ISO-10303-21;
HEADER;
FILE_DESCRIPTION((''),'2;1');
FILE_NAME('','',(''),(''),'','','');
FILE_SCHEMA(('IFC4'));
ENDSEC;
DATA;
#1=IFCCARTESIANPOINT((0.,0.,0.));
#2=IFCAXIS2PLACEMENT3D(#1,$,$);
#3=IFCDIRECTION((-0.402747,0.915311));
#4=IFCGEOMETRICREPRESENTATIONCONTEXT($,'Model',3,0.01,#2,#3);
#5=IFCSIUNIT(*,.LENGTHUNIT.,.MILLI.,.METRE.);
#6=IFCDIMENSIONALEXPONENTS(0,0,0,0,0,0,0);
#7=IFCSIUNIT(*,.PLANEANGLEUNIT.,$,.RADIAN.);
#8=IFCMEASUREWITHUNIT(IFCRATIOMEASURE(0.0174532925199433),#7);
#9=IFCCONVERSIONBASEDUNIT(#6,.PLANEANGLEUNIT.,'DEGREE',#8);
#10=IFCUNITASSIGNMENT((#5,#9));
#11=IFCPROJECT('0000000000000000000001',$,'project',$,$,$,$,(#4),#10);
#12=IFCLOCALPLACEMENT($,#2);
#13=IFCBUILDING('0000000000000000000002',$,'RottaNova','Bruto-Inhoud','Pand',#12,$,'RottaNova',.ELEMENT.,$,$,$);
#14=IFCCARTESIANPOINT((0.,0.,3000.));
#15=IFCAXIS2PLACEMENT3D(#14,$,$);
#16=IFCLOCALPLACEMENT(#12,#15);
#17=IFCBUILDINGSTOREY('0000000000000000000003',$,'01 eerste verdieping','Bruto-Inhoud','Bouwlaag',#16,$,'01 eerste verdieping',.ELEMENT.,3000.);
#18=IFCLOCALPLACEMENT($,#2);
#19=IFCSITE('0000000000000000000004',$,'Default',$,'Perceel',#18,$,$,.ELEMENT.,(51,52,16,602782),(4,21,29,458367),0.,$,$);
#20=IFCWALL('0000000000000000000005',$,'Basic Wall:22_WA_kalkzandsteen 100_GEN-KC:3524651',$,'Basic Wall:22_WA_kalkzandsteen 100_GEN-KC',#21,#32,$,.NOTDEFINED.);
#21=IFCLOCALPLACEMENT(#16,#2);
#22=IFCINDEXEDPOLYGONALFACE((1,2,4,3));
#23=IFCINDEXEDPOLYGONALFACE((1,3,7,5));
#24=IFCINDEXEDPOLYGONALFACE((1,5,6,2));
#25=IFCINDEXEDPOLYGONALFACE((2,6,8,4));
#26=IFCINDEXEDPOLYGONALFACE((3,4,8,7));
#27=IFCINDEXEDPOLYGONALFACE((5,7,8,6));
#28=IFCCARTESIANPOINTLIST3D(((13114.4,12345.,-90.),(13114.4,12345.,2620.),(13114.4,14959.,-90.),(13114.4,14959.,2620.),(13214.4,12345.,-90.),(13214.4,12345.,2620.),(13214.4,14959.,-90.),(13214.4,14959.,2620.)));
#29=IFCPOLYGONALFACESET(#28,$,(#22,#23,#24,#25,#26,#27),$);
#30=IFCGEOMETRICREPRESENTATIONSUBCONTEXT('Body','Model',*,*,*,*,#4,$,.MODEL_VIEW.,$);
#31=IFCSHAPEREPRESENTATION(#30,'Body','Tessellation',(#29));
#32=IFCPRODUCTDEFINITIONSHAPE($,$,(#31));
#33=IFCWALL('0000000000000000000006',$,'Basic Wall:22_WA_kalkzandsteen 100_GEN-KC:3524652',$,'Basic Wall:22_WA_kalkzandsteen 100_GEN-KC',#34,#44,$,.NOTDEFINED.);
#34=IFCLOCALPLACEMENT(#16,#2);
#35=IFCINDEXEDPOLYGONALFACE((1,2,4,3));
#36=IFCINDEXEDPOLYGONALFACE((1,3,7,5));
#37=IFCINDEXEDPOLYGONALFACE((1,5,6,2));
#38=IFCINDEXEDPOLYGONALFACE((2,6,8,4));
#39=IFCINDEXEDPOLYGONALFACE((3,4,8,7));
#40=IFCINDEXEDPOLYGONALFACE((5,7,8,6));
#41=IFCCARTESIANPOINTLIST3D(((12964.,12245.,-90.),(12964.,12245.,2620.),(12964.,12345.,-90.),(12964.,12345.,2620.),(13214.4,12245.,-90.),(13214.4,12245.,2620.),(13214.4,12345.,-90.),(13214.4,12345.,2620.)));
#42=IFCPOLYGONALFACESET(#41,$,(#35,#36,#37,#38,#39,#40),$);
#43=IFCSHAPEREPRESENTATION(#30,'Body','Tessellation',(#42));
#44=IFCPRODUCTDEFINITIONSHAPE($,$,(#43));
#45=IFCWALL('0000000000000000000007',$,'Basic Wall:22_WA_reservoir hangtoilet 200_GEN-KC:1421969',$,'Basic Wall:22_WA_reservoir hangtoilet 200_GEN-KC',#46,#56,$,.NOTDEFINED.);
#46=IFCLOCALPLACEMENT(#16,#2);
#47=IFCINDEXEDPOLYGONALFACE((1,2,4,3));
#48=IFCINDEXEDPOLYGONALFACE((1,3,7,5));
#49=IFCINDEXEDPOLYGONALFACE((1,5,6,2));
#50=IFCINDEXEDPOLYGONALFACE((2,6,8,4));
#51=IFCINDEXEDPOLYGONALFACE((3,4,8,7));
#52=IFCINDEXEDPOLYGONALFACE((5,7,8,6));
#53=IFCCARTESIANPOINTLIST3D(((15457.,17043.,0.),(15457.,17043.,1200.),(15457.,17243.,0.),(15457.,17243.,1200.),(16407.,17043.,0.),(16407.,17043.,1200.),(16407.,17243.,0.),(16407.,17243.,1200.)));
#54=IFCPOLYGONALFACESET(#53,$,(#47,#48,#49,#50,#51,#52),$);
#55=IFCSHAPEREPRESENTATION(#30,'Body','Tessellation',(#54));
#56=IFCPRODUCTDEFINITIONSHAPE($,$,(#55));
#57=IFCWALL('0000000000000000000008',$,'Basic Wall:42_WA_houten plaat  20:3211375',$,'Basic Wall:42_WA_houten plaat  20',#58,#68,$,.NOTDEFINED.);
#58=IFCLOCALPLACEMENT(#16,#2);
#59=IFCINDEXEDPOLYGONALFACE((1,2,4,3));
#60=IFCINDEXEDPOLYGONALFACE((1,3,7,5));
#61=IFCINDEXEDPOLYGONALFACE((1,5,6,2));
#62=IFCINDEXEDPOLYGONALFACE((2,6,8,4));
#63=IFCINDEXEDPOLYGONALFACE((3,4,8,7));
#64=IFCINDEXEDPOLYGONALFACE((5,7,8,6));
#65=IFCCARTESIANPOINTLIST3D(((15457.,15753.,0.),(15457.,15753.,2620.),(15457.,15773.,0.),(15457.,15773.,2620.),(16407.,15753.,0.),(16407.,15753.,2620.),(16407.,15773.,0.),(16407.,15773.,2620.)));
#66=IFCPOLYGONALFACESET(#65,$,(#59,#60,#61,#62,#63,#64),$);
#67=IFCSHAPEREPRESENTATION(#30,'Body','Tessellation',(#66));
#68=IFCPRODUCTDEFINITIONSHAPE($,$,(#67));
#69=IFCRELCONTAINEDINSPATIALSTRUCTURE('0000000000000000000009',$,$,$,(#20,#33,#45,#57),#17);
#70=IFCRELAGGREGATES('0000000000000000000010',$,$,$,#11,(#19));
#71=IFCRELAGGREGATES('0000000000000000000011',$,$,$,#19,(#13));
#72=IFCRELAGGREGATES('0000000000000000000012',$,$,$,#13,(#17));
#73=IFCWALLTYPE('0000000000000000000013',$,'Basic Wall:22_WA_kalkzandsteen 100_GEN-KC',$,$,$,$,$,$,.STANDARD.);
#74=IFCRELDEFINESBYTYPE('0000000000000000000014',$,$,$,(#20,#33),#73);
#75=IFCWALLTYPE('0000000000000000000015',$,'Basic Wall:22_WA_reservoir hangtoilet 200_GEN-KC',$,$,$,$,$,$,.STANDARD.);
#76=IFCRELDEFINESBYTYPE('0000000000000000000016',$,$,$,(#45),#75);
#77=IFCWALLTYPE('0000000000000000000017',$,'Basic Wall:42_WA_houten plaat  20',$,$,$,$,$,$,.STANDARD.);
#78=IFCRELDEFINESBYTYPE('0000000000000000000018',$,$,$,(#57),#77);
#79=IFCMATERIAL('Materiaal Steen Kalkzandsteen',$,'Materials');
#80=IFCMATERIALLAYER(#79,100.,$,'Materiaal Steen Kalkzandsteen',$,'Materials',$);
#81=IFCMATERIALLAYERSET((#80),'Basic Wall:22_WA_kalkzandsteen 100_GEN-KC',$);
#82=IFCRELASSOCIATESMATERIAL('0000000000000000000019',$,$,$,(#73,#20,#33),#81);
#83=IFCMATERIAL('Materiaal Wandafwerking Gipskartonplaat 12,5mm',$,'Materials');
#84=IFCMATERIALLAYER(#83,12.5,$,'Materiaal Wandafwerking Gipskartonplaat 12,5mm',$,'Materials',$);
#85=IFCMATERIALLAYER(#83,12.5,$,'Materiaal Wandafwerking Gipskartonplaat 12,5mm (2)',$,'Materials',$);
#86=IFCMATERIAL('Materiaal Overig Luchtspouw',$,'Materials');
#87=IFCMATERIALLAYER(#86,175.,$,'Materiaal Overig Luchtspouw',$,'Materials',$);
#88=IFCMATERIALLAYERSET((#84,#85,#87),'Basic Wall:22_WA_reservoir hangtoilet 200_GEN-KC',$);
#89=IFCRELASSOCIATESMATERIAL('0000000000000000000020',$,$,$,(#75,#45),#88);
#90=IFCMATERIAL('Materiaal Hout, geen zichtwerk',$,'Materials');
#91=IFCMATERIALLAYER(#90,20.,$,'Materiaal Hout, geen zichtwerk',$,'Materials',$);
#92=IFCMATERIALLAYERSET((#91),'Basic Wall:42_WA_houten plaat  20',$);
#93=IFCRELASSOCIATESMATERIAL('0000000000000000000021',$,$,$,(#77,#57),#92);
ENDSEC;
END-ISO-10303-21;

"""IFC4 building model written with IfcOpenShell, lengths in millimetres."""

from ifc_helpers import new_model, entity, si_unit, converted_unit, direction, frame, frame_2d, origin, place, context, subcontext, project, spatial, rectangle, extrude, material, layer, layer_set, type_object, element, save


model = new_model("IFC4")

# Units and contexts
model_context = context("Model", 3, precision=0.01, world=origin(), true_north=direction((-0.402747, 0.915311)))
body_context = subcontext(model_context, "Body", "Model", "MODEL_VIEW")
ifc_project = project(units=[si_unit("LENGTHUNIT", "METRE", prefix="MILLI"), converted_unit("PLANEANGLEUNIT", "DEGREE", entity("IfcRatioMeasure", 0.0174532925199433), si_unit("PLANEANGLEUNIT", "RADIAN"), dimensions=[0, 0, 0, 0, 0, 0, 0])], contexts=[model_context])

# Site, building, storey
site_placement = place(None, origin())
site = spatial("IfcSite", under=ifc_project, at=site_placement, Name="Default", ObjectType="Perceel", CompositionType="ELEMENT", RefLatitude=(51, 52, 16, 602782), RefLongitude=(4, 21, 29, 458367), RefElevation=0.0)
building_placement = place(None, origin())
building = spatial("IfcBuilding", under=site, at=building_placement, Name="RottaNova", Description="Bruto-Inhoud", ObjectType="Pand", LongName="RottaNova", CompositionType="ELEMENT")
storey_placement = place(building_placement, frame((0.0, 0.0, 3000.0)))
storey = spatial("IfcBuildingStorey", under=building, at=storey_placement, Name="01 eerste verdieping", Description="Bruto-Inhoud", ObjectType="Bouwlaag", LongName="01 eerste verdieping", CompositionType="ELEMENT", Elevation=3000.0)

# Shared definitions
ifc_material_1 = material(Name="Materiaal Steen Kalkzandsteen", Category="Materials")

# Walls
ifc_layer_1 = layer(ifc_material_1, 100.0, Name="Materiaal Steen Kalkzandsteen", Category="Materials")
ifc_layer_set_1 = layer_set([ifc_layer_1], Name="Basic Wall:22_WA_kalkzandsteen 100_GEN-KC")
wall_type_1 = type_object("IfcWallType", Name="Basic Wall:22_WA_kalkzandsteen 100_GEN-KC", PredefinedType="STANDARD", material=ifc_layer_set_1)
wall_1_placement = place(storey_placement, frame((13164.4, 14959.0, -90.0), z_axis=(0.0, 0.0, 1.0), x_axis=(0.0, -1.0, 0.0)))
element("IfcWall", 1, at=wall_1_placement, inside=storey, type_object=wall_type_1, material=ifc_layer_set_1, Name="Basic Wall:22_WA_kalkzandsteen 100_GEN-KC:3524651", ObjectType="Basic Wall:22_WA_kalkzandsteen 100_GEN-KC", PredefinedType="NOTDEFINED", context=body_context, shape_type="SweptSolid", body=[
    extrude(rectangle(XDim=2614.0, YDim=100.0, at=frame_2d((1307.0, 0.0), x_axis=(-1.0, 0.0))), origin(), (0.0, 0.0, 1.0), 2710.0),
])
wall_2_placement = place(storey_placement, frame((13214.4, 12295.0, -90.0), z_axis=(0.0, 0.0, 1.0), x_axis=(-1.0, 0.0, 0.0)))
element("IfcWall", 2, at=wall_2_placement, inside=storey, type_object=wall_type_1, material=ifc_layer_set_1, Name="Basic Wall:22_WA_kalkzandsteen 100_GEN-KC:3524652", ObjectType="Basic Wall:22_WA_kalkzandsteen 100_GEN-KC", PredefinedType="NOTDEFINED", context=body_context, shape_type="SweptSolid", body=[
    extrude(rectangle(XDim=250.4, YDim=100.0, at=frame_2d((125.2, 0.0), x_axis=(-1.0, 0.0))), origin(), (0.0, 0.0, 1.0), 2710.0),
])
ifc_material_2 = material(Name="Materiaal Wandafwerking Gipskartonplaat 12,5mm", Category="Materials")
ifc_layer_2 = layer(ifc_material_2, 12.5, Name="Materiaal Wandafwerking Gipskartonplaat 12,5mm", Category="Materials")
ifc_layer_3 = layer(ifc_material_2, 12.5, Name="Materiaal Wandafwerking Gipskartonplaat 12,5mm (2)", Category="Materials")
ifc_material_3 = material(Name="Materiaal Overig Luchtspouw", Category="Materials")
ifc_layer_4 = layer(ifc_material_3, 175.0, Name="Materiaal Overig Luchtspouw", Category="Materials")
ifc_layer_set_2 = layer_set([ifc_layer_2, ifc_layer_3, ifc_layer_4], Name="Basic Wall:22_WA_reservoir hangtoilet 200_GEN-KC")
wall_type_2 = type_object("IfcWallType", Name="Basic Wall:22_WA_reservoir hangtoilet 200_GEN-KC", PredefinedType="STANDARD", material=ifc_layer_set_2)
wall_3_placement = place(storey_placement, frame((16407.0, 17143.0, 0.0), z_axis=(0.0, 0.0, 1.0), x_axis=(-1.0, 0.0, 0.0)))
element("IfcWall", 3, at=wall_3_placement, inside=storey, type_object=wall_type_2, material=ifc_layer_set_2, Name="Basic Wall:22_WA_reservoir hangtoilet 200_GEN-KC:1421969", ObjectType="Basic Wall:22_WA_reservoir hangtoilet 200_GEN-KC", PredefinedType="NOTDEFINED", context=body_context, shape_type="SweptSolid", body=[
    extrude(rectangle(XDim=950.0, YDim=200.0, at=frame_2d((475.0, 0.0), x_axis=(-1.0, 0.0))), origin(), (0.0, 0.0, 1.0), 1200.0),
])
ifc_material_4 = material(Name="Materiaal Hout, geen zichtwerk", Category="Materials")
ifc_layer_5 = layer(ifc_material_4, 20.0, Name="Materiaal Hout, geen zichtwerk", Category="Materials")
ifc_layer_set_3 = layer_set([ifc_layer_5], Name="Basic Wall:42_WA_houten plaat  20")
wall_type_3 = type_object("IfcWallType", Name="Basic Wall:42_WA_houten plaat  20", PredefinedType="STANDARD", material=ifc_layer_set_3)
wall_4_placement = place(storey_placement, frame((16407.0, 15763.0, 0.0), z_axis=(0.0, 0.0, 1.0), x_axis=(-1.0, 0.0, 0.0)))
element("IfcWall", 4, at=wall_4_placement, inside=storey, type_object=wall_type_3, material=ifc_layer_set_3, Name="Basic Wall:42_WA_houten plaat  20:3211375", ObjectType="Basic Wall:42_WA_houten plaat  20", PredefinedType="NOTDEFINED", context=body_context, shape_type="SweptSolid", body=[
    extrude(rectangle(XDim=950.0, YDim=20.0, at=frame_2d((475.0, 0.0), x_axis=(-1.0, 0.0))), origin(), (0.0, 0.0, 1.0), 2620.0),
])

save(model, "model.ifc")
